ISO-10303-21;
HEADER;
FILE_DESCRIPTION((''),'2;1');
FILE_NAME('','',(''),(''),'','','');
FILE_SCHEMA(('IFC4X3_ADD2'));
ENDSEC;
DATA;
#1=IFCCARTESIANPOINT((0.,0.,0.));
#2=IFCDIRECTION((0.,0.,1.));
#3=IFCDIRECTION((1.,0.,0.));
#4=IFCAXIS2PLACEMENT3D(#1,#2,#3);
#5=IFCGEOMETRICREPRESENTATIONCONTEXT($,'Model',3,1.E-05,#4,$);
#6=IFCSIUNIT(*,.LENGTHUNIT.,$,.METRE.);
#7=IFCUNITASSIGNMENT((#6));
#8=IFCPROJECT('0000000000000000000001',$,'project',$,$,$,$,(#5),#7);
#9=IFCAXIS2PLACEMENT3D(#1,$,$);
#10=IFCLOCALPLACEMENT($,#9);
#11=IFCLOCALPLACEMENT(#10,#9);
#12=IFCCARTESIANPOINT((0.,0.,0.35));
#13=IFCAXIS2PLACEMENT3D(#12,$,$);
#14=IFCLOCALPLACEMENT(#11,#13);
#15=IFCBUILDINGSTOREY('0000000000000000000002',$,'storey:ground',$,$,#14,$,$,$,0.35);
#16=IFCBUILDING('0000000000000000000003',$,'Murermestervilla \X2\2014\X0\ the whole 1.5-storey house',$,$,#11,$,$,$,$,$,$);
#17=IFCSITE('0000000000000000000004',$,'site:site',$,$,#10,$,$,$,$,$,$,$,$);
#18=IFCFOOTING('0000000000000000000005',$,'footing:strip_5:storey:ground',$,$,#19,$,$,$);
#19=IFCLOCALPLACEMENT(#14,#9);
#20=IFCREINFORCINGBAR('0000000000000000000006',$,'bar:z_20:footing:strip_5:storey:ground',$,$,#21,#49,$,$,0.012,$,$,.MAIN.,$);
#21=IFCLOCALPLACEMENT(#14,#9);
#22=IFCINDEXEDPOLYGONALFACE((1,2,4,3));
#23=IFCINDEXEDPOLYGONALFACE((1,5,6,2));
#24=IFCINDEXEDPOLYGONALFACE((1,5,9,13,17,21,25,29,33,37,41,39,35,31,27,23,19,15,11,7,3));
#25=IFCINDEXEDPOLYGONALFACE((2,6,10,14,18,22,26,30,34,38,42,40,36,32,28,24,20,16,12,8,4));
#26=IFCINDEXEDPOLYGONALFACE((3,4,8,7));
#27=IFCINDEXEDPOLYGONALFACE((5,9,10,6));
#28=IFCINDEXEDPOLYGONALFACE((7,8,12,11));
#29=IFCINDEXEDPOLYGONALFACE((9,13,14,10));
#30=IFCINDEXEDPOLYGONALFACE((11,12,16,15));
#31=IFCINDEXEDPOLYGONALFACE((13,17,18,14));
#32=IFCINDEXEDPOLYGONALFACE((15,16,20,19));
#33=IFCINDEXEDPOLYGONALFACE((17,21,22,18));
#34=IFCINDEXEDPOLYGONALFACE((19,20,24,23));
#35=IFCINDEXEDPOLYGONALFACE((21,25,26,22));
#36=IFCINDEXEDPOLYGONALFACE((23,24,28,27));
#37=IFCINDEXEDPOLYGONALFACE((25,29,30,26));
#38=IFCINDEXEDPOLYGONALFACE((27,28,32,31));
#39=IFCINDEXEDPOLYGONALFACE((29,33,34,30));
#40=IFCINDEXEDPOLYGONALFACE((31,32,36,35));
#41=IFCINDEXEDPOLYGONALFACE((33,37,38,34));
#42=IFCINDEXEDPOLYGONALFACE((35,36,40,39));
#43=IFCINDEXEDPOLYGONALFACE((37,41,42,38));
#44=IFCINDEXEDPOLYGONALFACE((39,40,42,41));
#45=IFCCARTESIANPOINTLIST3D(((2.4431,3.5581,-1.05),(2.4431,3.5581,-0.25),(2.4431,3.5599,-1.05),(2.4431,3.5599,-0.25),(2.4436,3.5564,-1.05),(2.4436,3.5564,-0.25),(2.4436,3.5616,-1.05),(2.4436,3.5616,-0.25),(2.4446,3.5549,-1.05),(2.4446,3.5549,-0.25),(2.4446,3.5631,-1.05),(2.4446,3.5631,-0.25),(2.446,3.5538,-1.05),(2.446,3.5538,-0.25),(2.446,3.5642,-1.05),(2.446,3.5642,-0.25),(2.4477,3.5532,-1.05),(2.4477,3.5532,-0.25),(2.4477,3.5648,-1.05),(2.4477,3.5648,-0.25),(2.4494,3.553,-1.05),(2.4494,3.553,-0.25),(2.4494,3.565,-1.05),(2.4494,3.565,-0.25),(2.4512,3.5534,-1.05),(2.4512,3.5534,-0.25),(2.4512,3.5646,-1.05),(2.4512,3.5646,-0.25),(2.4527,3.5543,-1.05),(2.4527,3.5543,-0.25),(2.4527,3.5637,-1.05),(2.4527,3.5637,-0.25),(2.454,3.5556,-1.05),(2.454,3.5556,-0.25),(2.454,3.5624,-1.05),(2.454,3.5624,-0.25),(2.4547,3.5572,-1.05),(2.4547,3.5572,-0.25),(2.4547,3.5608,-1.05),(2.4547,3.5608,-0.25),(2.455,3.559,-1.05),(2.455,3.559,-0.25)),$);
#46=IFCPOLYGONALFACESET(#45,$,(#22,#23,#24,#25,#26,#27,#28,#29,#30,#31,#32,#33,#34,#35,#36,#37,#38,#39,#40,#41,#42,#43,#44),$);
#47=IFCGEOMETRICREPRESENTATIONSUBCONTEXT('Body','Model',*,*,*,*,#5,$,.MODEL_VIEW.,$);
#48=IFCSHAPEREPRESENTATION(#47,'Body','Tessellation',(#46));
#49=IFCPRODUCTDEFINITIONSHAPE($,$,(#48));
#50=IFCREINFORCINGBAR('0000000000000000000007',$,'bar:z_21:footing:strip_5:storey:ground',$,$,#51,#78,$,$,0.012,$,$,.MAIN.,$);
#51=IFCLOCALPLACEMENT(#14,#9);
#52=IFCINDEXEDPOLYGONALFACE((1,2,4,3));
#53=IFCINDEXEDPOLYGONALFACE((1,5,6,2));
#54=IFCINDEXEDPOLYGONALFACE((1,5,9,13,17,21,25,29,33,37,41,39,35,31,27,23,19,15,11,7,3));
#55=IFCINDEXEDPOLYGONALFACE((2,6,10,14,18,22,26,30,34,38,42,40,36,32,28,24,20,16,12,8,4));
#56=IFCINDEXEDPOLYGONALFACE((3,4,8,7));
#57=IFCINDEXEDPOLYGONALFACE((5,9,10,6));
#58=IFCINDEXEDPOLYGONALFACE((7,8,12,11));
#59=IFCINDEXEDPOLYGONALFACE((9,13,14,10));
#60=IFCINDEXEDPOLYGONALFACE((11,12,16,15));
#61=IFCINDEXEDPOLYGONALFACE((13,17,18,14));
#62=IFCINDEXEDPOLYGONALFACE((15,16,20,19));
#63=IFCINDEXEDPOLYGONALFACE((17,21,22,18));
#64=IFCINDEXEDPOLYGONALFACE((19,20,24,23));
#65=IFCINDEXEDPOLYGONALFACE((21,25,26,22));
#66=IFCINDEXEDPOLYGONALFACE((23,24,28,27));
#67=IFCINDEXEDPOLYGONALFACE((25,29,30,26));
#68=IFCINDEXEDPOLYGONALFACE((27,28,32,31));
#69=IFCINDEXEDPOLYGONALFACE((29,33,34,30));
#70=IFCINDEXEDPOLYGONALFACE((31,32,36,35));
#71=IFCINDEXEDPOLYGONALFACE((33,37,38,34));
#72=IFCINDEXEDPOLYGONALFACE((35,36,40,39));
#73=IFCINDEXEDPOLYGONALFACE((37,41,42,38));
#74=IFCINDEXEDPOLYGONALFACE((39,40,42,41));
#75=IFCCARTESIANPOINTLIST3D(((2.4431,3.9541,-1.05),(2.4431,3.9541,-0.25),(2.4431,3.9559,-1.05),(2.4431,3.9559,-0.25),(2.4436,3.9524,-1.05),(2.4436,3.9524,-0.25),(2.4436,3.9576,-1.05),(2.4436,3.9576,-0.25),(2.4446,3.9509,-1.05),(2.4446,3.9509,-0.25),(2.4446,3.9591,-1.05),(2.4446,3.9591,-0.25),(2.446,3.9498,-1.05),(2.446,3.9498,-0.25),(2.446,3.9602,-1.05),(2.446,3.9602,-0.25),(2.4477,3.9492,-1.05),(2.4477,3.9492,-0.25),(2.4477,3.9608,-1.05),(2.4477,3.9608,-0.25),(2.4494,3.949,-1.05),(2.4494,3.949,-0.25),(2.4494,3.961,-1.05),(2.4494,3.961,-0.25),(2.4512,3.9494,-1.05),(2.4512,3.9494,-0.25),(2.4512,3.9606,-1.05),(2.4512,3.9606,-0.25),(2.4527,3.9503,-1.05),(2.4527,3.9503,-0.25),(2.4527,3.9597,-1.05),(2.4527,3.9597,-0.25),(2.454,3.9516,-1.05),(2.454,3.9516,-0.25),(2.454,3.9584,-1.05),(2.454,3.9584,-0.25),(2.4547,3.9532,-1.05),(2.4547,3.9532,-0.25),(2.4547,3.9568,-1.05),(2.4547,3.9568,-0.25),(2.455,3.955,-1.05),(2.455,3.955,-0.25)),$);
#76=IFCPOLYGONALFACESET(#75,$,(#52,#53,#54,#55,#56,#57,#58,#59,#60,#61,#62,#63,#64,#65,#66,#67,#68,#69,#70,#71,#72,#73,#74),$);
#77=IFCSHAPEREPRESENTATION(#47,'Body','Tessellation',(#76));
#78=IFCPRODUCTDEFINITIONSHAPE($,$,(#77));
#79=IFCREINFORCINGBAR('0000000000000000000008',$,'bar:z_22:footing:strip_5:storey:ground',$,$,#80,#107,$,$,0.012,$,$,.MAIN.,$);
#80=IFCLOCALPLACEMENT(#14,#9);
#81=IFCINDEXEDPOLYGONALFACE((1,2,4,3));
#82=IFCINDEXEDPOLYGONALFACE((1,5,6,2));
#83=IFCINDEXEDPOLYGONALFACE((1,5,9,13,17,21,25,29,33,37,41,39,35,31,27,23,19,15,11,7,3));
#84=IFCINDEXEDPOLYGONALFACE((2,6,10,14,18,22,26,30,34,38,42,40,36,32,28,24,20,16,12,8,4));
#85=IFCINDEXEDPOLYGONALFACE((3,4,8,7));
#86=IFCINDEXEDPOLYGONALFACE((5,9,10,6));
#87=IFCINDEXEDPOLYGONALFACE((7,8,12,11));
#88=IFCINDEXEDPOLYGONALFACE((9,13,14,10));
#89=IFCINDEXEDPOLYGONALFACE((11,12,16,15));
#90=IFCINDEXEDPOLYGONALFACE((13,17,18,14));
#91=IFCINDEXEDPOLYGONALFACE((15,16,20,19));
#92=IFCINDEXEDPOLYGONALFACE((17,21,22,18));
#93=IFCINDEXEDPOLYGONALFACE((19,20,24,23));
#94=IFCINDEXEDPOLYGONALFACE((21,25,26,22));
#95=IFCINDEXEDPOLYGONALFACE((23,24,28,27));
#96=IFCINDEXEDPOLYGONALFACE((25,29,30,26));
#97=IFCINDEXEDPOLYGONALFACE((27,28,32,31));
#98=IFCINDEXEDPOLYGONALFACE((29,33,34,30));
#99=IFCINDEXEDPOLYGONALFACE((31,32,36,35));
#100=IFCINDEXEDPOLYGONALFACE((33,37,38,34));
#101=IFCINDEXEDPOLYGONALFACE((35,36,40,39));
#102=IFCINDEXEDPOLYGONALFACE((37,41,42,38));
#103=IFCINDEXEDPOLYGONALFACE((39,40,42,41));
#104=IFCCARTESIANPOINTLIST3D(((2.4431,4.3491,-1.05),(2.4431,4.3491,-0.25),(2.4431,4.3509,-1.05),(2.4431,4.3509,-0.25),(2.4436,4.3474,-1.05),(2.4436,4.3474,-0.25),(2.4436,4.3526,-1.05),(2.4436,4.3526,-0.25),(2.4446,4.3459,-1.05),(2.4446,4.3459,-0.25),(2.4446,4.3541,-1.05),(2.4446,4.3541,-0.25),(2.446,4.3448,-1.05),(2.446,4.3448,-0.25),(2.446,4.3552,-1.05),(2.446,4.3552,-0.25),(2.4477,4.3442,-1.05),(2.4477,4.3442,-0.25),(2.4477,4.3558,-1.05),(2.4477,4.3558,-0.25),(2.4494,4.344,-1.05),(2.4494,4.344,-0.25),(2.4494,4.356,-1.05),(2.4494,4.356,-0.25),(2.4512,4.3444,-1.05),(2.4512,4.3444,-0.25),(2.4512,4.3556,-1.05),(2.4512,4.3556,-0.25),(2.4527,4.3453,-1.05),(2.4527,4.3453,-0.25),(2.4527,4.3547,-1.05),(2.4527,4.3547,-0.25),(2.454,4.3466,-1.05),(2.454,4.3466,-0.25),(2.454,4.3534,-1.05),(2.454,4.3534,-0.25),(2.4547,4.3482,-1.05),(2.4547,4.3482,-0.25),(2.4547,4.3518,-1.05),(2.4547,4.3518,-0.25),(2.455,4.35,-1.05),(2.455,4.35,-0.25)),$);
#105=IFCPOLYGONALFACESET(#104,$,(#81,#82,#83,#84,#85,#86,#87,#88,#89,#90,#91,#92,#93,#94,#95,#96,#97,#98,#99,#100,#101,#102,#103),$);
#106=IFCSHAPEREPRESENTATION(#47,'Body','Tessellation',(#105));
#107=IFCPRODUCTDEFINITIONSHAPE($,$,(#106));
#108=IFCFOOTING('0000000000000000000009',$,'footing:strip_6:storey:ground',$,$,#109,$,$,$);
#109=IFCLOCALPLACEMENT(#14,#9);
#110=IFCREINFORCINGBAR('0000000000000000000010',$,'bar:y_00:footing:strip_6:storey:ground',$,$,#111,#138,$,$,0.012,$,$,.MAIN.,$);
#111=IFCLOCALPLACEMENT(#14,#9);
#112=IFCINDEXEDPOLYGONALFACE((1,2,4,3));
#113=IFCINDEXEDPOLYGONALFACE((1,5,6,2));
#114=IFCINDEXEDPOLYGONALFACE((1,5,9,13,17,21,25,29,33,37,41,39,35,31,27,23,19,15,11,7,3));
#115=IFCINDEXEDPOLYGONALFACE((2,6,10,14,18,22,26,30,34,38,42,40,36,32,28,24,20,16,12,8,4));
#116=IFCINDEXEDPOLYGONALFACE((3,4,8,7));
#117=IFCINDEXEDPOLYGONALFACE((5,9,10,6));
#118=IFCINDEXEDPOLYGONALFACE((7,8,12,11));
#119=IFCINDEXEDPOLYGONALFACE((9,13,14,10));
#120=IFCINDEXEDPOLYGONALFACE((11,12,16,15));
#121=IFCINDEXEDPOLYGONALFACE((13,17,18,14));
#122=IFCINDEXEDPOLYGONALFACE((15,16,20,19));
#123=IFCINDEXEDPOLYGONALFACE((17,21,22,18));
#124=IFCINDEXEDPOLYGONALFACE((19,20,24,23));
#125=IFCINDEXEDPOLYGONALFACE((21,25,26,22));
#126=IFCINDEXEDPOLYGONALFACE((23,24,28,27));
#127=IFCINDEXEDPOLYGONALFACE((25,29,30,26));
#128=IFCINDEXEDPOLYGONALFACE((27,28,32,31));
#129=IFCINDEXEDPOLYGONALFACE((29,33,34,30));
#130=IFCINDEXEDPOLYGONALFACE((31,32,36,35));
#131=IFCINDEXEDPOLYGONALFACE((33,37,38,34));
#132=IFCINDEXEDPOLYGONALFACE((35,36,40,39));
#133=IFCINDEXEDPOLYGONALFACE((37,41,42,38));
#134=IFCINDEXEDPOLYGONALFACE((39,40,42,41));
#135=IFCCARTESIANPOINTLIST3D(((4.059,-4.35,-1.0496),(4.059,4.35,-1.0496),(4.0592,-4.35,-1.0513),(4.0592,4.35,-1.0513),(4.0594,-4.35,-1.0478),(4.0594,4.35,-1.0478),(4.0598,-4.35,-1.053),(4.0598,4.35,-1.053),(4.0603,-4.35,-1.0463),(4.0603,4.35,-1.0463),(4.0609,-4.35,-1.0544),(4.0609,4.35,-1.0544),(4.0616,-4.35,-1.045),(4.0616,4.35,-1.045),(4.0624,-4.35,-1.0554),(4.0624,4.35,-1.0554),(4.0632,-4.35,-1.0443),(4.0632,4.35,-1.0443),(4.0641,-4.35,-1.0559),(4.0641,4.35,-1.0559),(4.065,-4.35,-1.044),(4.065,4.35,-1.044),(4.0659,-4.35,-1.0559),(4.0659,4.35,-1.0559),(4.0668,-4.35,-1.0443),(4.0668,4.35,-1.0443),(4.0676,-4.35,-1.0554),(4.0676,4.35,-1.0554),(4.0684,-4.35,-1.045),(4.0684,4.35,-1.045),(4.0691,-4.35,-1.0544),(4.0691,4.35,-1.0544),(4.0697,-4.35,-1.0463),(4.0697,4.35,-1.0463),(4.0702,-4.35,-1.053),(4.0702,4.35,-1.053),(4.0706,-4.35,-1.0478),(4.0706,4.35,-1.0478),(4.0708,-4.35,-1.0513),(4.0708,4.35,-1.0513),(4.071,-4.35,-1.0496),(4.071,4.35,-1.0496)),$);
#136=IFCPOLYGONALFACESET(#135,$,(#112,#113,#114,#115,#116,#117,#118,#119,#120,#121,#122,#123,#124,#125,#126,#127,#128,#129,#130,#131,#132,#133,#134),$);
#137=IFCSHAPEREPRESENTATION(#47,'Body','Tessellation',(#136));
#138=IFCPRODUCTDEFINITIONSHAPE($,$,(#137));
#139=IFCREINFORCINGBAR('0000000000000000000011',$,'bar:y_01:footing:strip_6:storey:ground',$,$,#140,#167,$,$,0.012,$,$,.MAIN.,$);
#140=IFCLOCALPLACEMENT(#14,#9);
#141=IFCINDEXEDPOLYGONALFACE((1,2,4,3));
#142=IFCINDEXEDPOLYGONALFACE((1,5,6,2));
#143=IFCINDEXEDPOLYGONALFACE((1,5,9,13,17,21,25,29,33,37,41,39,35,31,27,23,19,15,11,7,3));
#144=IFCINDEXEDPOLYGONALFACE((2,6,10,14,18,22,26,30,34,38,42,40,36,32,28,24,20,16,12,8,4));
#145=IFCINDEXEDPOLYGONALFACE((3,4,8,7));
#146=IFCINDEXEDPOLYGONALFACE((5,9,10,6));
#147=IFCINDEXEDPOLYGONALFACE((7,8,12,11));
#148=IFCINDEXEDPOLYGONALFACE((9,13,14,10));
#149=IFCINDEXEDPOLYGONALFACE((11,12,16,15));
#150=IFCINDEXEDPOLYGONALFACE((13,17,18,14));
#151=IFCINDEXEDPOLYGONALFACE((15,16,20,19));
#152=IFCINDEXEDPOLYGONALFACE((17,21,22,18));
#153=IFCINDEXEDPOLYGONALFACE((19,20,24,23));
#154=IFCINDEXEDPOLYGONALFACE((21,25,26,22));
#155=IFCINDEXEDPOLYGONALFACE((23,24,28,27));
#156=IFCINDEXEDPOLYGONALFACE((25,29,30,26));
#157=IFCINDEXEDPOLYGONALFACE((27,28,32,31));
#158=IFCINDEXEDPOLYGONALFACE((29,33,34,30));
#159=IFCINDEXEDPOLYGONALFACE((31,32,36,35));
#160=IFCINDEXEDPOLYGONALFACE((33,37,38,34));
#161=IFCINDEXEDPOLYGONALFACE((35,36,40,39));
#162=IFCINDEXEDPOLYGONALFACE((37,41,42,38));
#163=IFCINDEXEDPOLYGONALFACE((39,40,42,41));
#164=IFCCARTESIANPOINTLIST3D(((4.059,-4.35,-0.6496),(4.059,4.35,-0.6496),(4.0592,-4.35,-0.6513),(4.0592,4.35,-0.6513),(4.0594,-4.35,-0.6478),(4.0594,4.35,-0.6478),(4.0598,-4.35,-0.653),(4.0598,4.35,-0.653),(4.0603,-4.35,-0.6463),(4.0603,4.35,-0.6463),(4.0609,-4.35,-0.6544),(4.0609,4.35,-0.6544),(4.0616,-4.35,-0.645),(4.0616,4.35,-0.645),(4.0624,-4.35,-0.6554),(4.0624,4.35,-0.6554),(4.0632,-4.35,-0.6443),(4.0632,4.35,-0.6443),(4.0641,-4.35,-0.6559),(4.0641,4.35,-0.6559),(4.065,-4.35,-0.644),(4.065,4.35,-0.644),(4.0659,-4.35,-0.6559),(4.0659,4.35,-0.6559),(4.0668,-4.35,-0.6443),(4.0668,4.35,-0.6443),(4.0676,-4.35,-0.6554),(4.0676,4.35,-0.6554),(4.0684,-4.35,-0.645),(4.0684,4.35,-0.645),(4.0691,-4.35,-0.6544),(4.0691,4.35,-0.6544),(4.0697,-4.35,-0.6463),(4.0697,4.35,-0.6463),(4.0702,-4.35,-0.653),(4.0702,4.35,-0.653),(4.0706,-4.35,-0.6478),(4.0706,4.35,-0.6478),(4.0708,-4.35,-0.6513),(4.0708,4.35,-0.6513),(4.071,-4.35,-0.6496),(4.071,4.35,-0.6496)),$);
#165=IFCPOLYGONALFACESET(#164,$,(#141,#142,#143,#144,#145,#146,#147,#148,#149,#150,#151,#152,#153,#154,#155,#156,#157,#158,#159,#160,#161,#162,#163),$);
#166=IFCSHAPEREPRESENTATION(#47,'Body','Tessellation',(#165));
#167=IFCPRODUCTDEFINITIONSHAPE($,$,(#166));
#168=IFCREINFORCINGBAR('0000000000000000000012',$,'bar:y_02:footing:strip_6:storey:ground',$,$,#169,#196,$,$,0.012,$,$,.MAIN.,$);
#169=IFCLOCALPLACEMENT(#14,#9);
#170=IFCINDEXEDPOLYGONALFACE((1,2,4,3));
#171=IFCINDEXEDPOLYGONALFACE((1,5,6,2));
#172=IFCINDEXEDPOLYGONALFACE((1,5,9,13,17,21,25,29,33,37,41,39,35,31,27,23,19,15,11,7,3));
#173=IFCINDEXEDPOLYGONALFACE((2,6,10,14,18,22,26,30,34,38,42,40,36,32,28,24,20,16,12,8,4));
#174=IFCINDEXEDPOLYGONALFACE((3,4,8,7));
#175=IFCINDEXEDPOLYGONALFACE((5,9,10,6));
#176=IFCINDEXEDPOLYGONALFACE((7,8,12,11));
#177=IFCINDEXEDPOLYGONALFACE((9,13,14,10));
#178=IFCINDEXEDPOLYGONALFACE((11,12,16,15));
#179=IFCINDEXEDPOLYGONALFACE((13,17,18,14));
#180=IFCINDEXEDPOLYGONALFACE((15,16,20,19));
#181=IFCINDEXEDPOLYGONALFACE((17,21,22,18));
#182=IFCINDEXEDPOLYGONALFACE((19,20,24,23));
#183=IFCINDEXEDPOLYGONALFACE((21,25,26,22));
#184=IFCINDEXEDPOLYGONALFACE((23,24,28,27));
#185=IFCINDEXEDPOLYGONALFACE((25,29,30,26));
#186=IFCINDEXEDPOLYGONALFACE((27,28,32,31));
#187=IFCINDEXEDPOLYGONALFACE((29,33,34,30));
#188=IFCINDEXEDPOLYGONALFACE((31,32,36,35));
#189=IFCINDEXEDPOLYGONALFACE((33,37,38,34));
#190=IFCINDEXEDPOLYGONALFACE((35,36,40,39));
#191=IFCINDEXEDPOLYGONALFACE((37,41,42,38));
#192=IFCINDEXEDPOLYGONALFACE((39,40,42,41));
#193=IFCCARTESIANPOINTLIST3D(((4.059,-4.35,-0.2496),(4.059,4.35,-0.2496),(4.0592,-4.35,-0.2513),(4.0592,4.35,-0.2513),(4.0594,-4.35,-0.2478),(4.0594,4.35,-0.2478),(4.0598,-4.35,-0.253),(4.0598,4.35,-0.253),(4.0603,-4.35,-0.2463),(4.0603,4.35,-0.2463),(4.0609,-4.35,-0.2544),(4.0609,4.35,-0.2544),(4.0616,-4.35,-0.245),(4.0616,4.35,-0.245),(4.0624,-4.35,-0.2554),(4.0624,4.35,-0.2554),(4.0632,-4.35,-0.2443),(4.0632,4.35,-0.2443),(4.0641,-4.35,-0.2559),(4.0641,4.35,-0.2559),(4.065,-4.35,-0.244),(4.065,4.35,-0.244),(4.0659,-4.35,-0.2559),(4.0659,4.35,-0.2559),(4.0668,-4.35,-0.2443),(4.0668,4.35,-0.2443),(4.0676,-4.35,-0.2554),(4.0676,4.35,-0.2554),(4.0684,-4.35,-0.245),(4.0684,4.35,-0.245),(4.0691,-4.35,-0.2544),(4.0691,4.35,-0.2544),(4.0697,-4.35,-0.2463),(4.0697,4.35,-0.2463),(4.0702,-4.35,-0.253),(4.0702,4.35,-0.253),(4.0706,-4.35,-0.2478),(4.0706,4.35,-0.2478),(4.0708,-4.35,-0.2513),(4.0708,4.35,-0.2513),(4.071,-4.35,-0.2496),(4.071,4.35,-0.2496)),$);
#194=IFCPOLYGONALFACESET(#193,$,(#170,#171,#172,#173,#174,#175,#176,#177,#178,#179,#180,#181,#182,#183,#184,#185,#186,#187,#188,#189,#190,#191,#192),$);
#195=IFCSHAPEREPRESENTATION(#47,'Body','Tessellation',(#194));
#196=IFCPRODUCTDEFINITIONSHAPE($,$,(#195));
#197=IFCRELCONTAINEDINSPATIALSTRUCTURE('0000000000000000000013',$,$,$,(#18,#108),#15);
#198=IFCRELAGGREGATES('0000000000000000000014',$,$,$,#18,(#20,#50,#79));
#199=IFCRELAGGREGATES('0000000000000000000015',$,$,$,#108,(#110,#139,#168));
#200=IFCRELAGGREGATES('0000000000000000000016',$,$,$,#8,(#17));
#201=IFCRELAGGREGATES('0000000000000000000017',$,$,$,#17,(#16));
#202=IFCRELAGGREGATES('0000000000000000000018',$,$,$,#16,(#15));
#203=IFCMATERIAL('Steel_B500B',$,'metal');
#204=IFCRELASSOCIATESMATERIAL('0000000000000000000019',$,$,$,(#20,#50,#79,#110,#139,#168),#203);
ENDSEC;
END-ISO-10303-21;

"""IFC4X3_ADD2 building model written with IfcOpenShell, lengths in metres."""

from ifc_helpers import new_model, entity, si_unit, frame, origin, origin_with_axes, place, context, subcontext, project, spatial, material, element, aggregate, save


model = new_model("IFC4X3_ADD2")

# Units and contexts
model_context = context("Model", 3, precision=1e-05, world=origin_with_axes())
body_context = subcontext(model_context, "Body", "Model", "MODEL_VIEW")
ifc_project = project(units=[si_unit("LENGTHUNIT", "METRE")], contexts=[model_context])

# Site, building, storey
placement_1 = place(None, origin())
site = spatial("IfcSite", under=ifc_project, at=placement_1, Name="site:site")
building_placement = place(placement_1, origin())
building = spatial("IfcBuilding", under=site, at=building_placement, Name="Murermestervilla — the whole 1.5-storey house")
storey_placement = place(building_placement, frame((0.0, 0.0, 0.35)))
storey = spatial("IfcBuildingStorey", under=building, at=storey_placement, Name="storey:ground", Elevation=0.35)

# Footings, reinforcing bars
placement_2 = place(storey_placement, frame((0.0, 0.0, -0.35)))
ifc_material = material(Name="Steel_B500B", Category="metal")
footing_1 = element("IfcFooting", 1, at=placement_2, inside=storey, Name="footing:strip_5:storey:ground")
reinforcing_bar_1 = element("IfcReinforcingBar", 2, at=placement_1, material=ifc_material, Name="bar:z_20:footing:strip_5:storey:ground", NominalDiameter=0.012, PredefinedType="MAIN", context=body_context, shape_type="AdvancedSweptSolid", body=[
    entity("IfcSweptDiskSolid", entity("IfcPolyline", [entity("IfcCartesianPoint", [2.449, 3.559, -0.7]), entity("IfcCartesianPoint", [2.449, 3.559, 0.1])]), 0.006),
])
reinforcing_bar_2 = element("IfcReinforcingBar", 3, at=placement_1, material=ifc_material, Name="bar:z_21:footing:strip_5:storey:ground", NominalDiameter=0.012, PredefinedType="MAIN", context=body_context, shape_type="AdvancedSweptSolid", body=[
    entity("IfcSweptDiskSolid", entity("IfcPolyline", [entity("IfcCartesianPoint", [2.449, 3.955, -0.7]), entity("IfcCartesianPoint", [2.449, 3.955, 0.1])]), 0.006),
])
reinforcing_bar_3 = element("IfcReinforcingBar", 4, at=placement_1, material=ifc_material, Name="bar:z_22:footing:strip_5:storey:ground", NominalDiameter=0.012, PredefinedType="MAIN", context=body_context, shape_type="AdvancedSweptSolid", body=[
    entity("IfcSweptDiskSolid", entity("IfcPolyline", [entity("IfcCartesianPoint", [2.449, 4.35, -0.7]), entity("IfcCartesianPoint", [2.449, 4.35, 0.1])]), 0.006),
])
aggregate(footing_1, [reinforcing_bar_1, reinforcing_bar_2, reinforcing_bar_3])
footing_2 = element("IfcFooting", 5, at=placement_2, inside=storey, Name="footing:strip_6:storey:ground")
reinforcing_bar_4 = element("IfcReinforcingBar", 6, at=placement_1, material=ifc_material, Name="bar:y_00:footing:strip_6:storey:ground", NominalDiameter=0.012, PredefinedType="MAIN", context=body_context, shape_type="AdvancedSweptSolid", body=[
    entity("IfcSweptDiskSolid", entity("IfcPolyline", [entity("IfcCartesianPoint", [4.065, -4.35, -0.7]), entity("IfcCartesianPoint", [4.065, 4.35, -0.7])]), 0.006),
])
reinforcing_bar_5 = element("IfcReinforcingBar", 7, at=placement_1, material=ifc_material, Name="bar:y_01:footing:strip_6:storey:ground", NominalDiameter=0.012, PredefinedType="MAIN", context=body_context, shape_type="AdvancedSweptSolid", body=[
    entity("IfcSweptDiskSolid", entity("IfcPolyline", [entity("IfcCartesianPoint", [4.065, -4.35, -0.3]), entity("IfcCartesianPoint", [4.065, 4.35, -0.3])]), 0.006),
])
reinforcing_bar_6 = element("IfcReinforcingBar", 8, at=placement_1, material=ifc_material, Name="bar:y_02:footing:strip_6:storey:ground", NominalDiameter=0.012, PredefinedType="MAIN", context=body_context, shape_type="AdvancedSweptSolid", body=[
    entity("IfcSweptDiskSolid", entity("IfcPolyline", [entity("IfcCartesianPoint", [4.065, -4.35, 0.1]), entity("IfcCartesianPoint", [4.065, 4.35, 0.1])]), 0.006),
])
aggregate(footing_2, [reinforcing_bar_4, reinforcing_bar_5, reinforcing_bar_6])

save(model, "model.ifc")
